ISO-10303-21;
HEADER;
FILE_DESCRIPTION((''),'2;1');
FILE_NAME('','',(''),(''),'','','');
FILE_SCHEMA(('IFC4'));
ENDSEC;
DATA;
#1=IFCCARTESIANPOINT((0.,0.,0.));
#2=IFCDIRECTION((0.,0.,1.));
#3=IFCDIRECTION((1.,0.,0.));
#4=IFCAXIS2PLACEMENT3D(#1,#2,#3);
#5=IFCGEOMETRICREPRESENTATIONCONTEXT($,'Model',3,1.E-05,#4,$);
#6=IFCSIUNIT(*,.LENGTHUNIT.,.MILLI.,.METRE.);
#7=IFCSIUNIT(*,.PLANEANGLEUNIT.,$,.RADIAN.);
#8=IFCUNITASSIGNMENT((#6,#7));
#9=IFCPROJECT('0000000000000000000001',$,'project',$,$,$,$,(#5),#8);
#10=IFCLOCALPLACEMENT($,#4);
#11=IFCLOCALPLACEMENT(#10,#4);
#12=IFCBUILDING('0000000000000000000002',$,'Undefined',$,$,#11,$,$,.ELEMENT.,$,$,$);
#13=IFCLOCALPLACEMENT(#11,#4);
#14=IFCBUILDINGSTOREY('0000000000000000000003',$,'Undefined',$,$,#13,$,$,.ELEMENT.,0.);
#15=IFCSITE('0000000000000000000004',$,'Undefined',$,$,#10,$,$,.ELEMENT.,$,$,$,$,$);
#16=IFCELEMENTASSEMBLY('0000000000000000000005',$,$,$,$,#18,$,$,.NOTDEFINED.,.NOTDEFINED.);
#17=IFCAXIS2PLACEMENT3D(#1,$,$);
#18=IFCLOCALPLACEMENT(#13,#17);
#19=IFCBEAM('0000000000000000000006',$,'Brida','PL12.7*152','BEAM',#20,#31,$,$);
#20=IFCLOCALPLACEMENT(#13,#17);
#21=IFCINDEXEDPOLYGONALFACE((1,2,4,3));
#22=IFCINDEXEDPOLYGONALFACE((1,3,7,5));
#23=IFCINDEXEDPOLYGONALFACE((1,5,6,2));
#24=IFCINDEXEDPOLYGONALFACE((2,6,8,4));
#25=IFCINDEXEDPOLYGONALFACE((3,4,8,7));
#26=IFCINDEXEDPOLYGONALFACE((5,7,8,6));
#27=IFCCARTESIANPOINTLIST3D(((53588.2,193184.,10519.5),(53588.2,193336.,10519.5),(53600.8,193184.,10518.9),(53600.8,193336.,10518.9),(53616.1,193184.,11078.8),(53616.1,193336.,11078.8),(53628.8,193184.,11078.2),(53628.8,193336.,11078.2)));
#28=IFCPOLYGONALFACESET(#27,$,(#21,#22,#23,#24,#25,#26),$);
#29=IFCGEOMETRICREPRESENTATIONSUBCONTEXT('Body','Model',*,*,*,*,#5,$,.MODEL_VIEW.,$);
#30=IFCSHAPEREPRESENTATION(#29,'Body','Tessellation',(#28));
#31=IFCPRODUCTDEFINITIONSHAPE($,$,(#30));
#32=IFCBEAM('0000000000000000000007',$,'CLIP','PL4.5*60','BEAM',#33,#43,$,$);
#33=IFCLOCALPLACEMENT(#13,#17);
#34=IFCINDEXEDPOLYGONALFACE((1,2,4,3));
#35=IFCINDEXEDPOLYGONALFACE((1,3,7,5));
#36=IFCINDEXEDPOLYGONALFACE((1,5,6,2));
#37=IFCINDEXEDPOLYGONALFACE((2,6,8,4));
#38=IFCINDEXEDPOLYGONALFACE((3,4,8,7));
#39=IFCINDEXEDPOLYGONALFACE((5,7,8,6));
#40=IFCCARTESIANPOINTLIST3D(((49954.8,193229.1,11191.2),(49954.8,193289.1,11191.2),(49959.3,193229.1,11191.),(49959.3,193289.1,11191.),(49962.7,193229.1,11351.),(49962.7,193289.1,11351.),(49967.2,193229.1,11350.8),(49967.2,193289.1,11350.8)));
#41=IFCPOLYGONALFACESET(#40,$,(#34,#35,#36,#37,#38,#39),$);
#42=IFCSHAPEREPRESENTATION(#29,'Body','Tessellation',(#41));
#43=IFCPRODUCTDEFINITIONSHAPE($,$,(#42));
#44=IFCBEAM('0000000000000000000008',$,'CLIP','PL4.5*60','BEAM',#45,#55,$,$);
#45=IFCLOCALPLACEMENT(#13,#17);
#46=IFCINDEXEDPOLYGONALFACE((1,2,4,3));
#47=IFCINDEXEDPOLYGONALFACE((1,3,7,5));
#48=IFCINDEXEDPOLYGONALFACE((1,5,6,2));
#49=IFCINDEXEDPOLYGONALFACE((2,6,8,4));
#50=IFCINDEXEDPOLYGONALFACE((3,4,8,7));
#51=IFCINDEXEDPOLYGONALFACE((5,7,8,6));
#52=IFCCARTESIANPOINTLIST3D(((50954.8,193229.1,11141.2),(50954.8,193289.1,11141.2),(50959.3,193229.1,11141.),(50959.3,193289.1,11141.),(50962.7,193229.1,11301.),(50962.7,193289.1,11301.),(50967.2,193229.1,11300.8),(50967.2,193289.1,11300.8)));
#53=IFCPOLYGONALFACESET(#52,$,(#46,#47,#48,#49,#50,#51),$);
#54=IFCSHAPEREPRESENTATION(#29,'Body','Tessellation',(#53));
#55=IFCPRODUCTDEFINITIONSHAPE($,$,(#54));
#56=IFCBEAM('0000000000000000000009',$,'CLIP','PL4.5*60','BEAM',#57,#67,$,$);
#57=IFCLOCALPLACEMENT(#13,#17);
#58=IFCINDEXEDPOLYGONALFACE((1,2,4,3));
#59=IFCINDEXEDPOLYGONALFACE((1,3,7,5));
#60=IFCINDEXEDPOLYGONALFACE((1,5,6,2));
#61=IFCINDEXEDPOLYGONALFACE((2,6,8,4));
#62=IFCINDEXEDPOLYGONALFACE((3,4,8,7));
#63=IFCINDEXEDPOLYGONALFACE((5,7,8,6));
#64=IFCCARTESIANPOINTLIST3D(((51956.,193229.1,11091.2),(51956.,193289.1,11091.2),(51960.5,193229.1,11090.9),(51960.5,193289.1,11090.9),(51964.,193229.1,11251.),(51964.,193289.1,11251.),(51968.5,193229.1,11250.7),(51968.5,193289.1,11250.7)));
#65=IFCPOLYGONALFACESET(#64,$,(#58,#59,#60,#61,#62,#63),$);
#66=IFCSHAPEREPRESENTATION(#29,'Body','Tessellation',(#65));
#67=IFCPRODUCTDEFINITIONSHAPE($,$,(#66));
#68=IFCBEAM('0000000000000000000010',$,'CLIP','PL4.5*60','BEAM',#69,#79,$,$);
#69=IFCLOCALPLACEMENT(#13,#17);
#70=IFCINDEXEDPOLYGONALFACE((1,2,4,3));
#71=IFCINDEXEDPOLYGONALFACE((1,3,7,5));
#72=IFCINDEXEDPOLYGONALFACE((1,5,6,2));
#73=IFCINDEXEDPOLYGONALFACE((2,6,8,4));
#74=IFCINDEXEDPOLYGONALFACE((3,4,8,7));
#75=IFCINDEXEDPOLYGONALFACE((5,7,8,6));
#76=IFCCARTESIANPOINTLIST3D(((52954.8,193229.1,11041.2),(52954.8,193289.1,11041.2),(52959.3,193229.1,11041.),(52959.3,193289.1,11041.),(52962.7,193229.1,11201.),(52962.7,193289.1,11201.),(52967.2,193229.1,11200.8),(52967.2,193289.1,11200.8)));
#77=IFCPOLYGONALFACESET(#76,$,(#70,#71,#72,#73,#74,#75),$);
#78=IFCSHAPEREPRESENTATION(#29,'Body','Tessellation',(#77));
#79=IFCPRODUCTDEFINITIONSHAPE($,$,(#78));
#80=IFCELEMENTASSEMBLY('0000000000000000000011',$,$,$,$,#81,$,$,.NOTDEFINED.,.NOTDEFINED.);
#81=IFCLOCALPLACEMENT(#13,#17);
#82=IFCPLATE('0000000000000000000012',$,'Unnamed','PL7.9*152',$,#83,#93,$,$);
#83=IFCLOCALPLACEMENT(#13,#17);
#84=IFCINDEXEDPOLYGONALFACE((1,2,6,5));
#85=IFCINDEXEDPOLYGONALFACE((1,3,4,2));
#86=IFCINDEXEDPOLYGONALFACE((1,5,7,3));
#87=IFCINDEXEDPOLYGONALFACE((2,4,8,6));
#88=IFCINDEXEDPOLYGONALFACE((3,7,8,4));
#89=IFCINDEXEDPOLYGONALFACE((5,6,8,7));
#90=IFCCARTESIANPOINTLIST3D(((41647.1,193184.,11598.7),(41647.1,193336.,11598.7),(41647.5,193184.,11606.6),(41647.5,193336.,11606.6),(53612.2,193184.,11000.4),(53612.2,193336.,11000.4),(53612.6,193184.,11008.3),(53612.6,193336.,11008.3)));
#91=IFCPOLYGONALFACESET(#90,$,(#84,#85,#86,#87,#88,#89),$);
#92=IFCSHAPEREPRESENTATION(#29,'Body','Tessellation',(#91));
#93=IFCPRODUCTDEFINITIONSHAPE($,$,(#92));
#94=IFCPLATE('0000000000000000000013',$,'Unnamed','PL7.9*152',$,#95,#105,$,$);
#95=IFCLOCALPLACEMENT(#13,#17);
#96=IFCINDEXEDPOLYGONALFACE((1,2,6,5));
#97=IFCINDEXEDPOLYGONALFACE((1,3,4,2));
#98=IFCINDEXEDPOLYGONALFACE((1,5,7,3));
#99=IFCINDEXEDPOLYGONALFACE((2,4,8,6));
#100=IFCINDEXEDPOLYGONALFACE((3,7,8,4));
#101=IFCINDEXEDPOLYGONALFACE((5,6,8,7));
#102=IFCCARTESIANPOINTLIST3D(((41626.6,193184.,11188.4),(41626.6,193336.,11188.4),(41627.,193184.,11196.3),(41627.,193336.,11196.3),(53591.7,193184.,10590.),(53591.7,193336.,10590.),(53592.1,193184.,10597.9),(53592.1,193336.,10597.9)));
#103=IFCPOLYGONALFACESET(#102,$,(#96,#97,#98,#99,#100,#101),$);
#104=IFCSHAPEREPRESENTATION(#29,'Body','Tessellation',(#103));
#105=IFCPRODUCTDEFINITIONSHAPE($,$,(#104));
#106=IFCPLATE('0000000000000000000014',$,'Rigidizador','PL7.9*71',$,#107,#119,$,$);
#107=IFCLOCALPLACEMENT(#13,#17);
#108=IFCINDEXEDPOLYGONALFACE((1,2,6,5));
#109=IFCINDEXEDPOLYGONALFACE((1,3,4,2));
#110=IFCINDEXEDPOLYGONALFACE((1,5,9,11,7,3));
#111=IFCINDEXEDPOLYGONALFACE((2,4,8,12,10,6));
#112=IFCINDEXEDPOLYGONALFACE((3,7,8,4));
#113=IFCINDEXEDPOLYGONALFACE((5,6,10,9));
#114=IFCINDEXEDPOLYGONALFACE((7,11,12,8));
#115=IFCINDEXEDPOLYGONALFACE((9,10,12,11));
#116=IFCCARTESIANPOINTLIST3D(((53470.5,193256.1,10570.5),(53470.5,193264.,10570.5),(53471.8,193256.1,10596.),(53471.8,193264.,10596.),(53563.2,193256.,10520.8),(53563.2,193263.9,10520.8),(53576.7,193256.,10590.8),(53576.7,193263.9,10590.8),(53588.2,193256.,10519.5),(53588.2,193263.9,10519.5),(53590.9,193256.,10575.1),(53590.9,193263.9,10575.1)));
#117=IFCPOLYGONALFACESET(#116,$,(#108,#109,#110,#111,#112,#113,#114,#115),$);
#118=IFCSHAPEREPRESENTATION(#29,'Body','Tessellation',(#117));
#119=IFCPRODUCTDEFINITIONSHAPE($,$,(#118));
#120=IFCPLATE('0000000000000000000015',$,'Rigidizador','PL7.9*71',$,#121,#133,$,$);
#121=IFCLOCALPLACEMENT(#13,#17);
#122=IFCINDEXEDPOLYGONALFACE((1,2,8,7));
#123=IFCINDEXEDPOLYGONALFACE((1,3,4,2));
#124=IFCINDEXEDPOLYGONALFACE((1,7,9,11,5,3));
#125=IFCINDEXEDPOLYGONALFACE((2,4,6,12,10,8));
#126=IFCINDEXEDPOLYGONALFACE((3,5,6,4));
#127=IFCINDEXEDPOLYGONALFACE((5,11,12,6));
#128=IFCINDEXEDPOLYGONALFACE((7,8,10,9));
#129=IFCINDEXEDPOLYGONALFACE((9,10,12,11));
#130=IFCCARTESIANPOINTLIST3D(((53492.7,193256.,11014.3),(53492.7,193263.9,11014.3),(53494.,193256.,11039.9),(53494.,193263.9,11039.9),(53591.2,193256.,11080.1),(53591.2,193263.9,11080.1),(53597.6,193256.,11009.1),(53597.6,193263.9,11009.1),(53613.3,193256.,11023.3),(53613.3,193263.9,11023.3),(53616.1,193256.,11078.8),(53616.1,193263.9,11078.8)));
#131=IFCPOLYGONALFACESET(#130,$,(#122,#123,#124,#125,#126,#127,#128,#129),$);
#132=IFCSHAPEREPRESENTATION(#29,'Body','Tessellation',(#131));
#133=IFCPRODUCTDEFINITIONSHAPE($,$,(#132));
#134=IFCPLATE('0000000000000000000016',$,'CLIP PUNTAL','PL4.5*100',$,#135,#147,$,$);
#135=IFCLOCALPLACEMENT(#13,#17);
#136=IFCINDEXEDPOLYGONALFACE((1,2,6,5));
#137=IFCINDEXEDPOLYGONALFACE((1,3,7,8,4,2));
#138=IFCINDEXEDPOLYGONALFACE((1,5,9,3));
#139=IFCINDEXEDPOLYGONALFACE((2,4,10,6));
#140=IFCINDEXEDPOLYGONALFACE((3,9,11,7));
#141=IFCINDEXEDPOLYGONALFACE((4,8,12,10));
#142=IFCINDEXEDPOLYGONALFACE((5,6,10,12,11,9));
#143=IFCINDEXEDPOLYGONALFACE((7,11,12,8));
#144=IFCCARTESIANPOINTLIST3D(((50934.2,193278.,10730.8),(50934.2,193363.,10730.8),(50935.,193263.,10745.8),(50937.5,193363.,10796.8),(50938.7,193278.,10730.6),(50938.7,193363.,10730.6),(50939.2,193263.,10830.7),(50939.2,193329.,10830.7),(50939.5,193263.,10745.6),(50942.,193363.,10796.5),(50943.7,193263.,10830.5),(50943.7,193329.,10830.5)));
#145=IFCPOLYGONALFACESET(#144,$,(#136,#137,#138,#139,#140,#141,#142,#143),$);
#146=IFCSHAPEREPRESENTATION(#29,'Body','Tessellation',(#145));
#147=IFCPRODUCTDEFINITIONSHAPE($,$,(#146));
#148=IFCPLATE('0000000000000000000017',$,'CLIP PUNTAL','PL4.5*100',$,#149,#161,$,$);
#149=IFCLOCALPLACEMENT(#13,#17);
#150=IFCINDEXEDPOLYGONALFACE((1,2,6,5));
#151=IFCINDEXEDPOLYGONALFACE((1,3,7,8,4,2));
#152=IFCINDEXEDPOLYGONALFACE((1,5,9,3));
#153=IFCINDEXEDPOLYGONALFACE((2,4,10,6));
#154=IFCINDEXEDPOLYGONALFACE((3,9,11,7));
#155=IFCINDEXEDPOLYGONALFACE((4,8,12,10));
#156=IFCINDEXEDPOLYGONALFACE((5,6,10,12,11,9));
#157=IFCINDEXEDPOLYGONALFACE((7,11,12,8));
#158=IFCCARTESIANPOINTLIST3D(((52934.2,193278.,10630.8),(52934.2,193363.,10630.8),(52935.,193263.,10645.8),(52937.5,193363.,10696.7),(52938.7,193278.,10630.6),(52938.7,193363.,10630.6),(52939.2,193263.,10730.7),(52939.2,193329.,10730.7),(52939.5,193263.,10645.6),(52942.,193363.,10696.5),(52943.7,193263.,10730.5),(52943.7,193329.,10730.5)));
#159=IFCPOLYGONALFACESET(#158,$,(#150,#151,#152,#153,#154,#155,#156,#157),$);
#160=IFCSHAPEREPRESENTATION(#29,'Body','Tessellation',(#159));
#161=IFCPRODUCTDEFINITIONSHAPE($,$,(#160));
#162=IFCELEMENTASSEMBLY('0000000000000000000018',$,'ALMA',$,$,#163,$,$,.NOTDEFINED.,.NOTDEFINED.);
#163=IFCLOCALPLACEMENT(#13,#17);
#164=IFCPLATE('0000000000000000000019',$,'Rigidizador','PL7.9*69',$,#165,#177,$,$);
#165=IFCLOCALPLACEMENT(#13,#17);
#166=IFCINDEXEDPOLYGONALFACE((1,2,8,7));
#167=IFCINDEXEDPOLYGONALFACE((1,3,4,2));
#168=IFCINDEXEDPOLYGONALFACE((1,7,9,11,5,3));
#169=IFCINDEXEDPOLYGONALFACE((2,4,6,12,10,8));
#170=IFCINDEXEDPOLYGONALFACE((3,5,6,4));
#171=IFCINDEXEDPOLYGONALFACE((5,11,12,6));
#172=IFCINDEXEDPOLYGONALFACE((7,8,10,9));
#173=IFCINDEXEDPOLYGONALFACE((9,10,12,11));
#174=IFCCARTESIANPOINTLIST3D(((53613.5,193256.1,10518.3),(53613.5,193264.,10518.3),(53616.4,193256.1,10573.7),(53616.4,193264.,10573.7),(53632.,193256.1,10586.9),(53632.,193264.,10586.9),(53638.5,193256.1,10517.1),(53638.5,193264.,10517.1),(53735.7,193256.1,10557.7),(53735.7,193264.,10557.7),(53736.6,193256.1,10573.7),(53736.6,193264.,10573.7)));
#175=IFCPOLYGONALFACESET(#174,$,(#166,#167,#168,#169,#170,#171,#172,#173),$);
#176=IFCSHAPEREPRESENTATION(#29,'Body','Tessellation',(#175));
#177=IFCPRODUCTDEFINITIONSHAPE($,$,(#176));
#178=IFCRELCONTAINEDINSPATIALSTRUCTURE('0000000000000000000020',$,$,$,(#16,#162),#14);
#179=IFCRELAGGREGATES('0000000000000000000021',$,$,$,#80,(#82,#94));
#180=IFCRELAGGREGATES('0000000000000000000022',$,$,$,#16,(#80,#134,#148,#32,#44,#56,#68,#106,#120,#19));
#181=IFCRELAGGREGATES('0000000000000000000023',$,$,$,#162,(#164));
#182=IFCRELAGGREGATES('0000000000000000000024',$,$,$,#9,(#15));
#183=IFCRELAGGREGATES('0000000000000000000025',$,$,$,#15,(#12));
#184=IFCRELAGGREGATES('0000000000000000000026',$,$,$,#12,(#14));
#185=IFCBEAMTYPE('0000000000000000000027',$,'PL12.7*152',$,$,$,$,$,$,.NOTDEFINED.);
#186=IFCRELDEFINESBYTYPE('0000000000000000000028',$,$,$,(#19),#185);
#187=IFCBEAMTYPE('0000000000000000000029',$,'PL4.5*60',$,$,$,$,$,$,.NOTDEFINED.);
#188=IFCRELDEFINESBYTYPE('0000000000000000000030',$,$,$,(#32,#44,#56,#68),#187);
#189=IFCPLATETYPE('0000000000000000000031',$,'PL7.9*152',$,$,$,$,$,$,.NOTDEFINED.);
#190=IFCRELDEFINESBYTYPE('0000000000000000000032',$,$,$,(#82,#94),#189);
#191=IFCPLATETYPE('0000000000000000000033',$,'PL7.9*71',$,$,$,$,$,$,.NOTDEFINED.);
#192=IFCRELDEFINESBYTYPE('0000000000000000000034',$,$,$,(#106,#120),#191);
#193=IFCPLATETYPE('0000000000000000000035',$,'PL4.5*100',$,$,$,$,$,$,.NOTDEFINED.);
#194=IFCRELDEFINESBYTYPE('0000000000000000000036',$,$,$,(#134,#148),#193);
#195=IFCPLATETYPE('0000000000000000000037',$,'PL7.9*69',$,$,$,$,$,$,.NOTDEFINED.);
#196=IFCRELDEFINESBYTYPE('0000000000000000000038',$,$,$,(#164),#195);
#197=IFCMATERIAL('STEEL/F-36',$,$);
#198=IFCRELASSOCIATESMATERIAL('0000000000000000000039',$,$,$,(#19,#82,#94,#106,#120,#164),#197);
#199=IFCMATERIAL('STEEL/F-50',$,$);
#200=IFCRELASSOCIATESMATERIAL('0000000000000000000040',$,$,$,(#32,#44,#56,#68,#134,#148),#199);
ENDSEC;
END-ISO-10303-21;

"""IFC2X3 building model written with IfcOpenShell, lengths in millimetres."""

from ifc_helpers import new_model, si_unit, frame, origin_with_axes, origin_2d_with_axis, place, context, subcontext, project, spatial, polyline, rectangle, outline, extrude, material, type_object, element, aggregate, save


model = new_model("IFC2X3")

# Units and contexts
model_context = context("Model", 3, precision=1e-05, world=origin_with_axes())
body_context = subcontext(model_context, "Body", "Model", "MODEL_VIEW")
ifc_project = project(units=[si_unit("LENGTHUNIT", "METRE", prefix="MILLI"), si_unit("PLANEANGLEUNIT", "RADIAN")], contexts=[model_context])

# Site, building, storey
site_placement = place(None, origin_with_axes())
site = spatial("IfcSite", under=ifc_project, at=site_placement, Name="Undefined", CompositionType="ELEMENT")
building_placement = place(site_placement, origin_with_axes())
building = spatial("IfcBuilding", under=site, at=building_placement, Name="Undefined", CompositionType="ELEMENT")
storey_placement = place(building_placement, origin_with_axes())
storey = spatial("IfcBuildingStorey", under=building, at=storey_placement, Name="Undefined", CompositionType="ELEMENT", Elevation=0.0)

# Element assemblies, beams, plates
assembly_1_placement = place(storey_placement, origin_with_axes())
assembly_1 = element("IfcElementAssembly", 1, at=assembly_1_placement, inside=storey, AssemblyPlace="NOTDEFINED", PredefinedType="NOTDEFINED")
ifc_material_1 = material(Name="STEEL/F-36")
beam_type_1 = type_object("IfcBeamType", Name="PL12.7*152", PredefinedType="NOTDEFINED")
beam_1_placement = place(assembly_1_placement, frame((53622.5, 193260.0, 11078.5), z_axis=(0.0, 1.0, 0.0), x_axis=(-0.049943, 0.0, -0.998752)))
beam_1 = element("IfcBeam", 2, at=beam_1_placement, type_object=beam_type_1, material=ifc_material_1, Name="Brida", Description="PL12.7*152", ObjectType="BEAM", context=body_context, shape_type="SweptSolid", body=[
    extrude(rectangle(XDim=12.7, YDim=152.0, at=origin_2d_with_axis()), frame((560.0, 0.0, 0.0), z_axis=(-1.0, 0.0, 0.0), x_axis=(0.0, -1.0, 0.0)), (0.0, 0.0, 1.0), 560.0),
])
ifc_material_2 = material(Name="STEEL/F-50")
beam_type_2 = type_object("IfcBeamType", Name="PL4.5*60", PredefinedType="NOTDEFINED")
beam_2_placement = place(assembly_1_placement, frame((49965.0, 193259.1, 11350.9), z_axis=(0.0, 1.0, 0.0), x_axis=(-0.049943, 0.0, -0.998752)))
beam_2 = element("IfcBeam", 3, at=beam_2_placement, type_object=beam_type_2, material=ifc_material_2, Name="CLIP", Description="PL4.5*60", ObjectType="BEAM", context=body_context, shape_type="SweptSolid", body=[
    extrude(rectangle(XDim=4.5, YDim=60.0, at=origin_2d_with_axis()), frame((160.0, 0.0, 0.0), z_axis=(-1.0, 0.0, 0.0), x_axis=(0.0, -1.0, 0.0)), (0.0, 0.0, 1.0), 160.0),
])
beam_3_placement = place(assembly_1_placement, frame((50965.0, 193259.1, 11300.9), z_axis=(0.0, 1.0, 0.0), x_axis=(-0.049943, 0.0, -0.998752)))
beam_3 = element("IfcBeam", 4, at=beam_3_placement, type_object=beam_type_2, material=ifc_material_2, Name="CLIP", Description="PL4.5*60", ObjectType="BEAM", context=body_context, shape_type="SweptSolid", body=[
    extrude(rectangle(XDim=4.5, YDim=60.0, at=origin_2d_with_axis()), frame((160.0, 0.0, 0.0), z_axis=(-1.0, 0.0, 0.0), x_axis=(0.0, -1.0, 0.0)), (0.0, 0.0, 1.0), 160.0),
])
beam_4_placement = place(assembly_1_placement, frame((51966.2, 193259.1, 11250.9), z_axis=(0.0, 1.0, 0.0), x_axis=(-0.049943, 0.0, -0.998752)))
beam_4 = element("IfcBeam", 5, at=beam_4_placement, type_object=beam_type_2, material=ifc_material_2, Name="CLIP", Description="PL4.5*60", ObjectType="BEAM", context=body_context, shape_type="SweptSolid", body=[
    extrude(rectangle(XDim=4.5, YDim=60.0, at=origin_2d_with_axis()), frame((160.0, 0.0, 0.0), z_axis=(-1.0, 0.0, 0.0), x_axis=(0.0, -1.0, 0.0)), (0.0, 0.0, 1.0), 160.0),
])
beam_5_placement = place(assembly_1_placement, frame((52965.0, 193259.1, 11200.9), z_axis=(0.0, 1.0, 0.0), x_axis=(-0.049943, 0.0, -0.998752)))
beam_5 = element("IfcBeam", 6, at=beam_5_placement, type_object=beam_type_2, material=ifc_material_2, Name="CLIP", Description="PL4.5*60", ObjectType="BEAM", context=body_context, shape_type="SweptSolid", body=[
    extrude(rectangle(XDim=4.5, YDim=60.0, at=origin_2d_with_axis()), frame((160.0, 0.0, 0.0), z_axis=(-1.0, 0.0, 0.0), x_axis=(0.0, -1.0, 0.0)), (0.0, 0.0, 1.0), 160.0),
])
assembly_2_placement = place(assembly_1_placement, origin_with_axes())
assembly_2 = element("IfcElementAssembly", 7, at=assembly_2_placement, AssemblyPlace="NOTDEFINED", PredefinedType="NOTDEFINED")
plate_type_1 = type_object("IfcPlateType", Name="PL7.9*152", PredefinedType="NOTDEFINED")
plate_1_placement = place(assembly_2_placement, frame((53612.4, 193260.0, 11004.4), z_axis=(-0.049943, 0.0, -0.998752), x_axis=(-0.998752, 0.0, 0.049943)))
plate_1 = element("IfcPlate", 8, at=plate_1_placement, type_object=plate_type_1, material=ifc_material_1, Name="Unnamed", Description="PL7.9*152", context=body_context, shape_type="SweptSolid", body=[
    extrude(outline(polyline([(0.0, -76.0), (0.0, 76.0), (11980.0, 76.0), (11980.0, -76.0), (0.0, -76.0)])), frame((0.0, 0.0, -4.0), z_axis=(0.0, 0.0, 1.0), x_axis=(1.0, 0.0, 0.0)), (0.0, 0.0, 1.0), 7.9),
])
plate_2_placement = place(assembly_2_placement, frame((53591.9, 193260.0, 10594.0), z_axis=(0.049943, 0.0, 0.998752), x_axis=(-0.998752, 0.0, 0.049943)))
plate_2 = element("IfcPlate", 9, at=plate_2_placement, type_object=plate_type_1, material=ifc_material_1, Name="Unnamed", Description="PL7.9*152", context=body_context, shape_type="SweptSolid", body=[
    extrude(outline(polyline([(0.0, -76.0), (0.0, 76.0), (11980.0, 76.0), (11980.0, -76.0), (0.0, -76.0)])), frame((0.0, 0.0, -4.0), z_axis=(0.0, 0.0, 1.0), x_axis=(1.0, 0.0, 0.0)), (0.0, 0.0, 1.0), 7.9),
])
aggregate(assembly_2, [plate_1, plate_2])
plate_type_2 = type_object("IfcPlateType", Name="PL7.9*71", PredefinedType="NOTDEFINED")
plate_3_placement = place(assembly_1_placement, frame((53588.2, 193260.0, 10519.5), z_axis=(0.0, -1.0, 0.0), x_axis=(0.049943, 0.0, 0.998752)))
plate_3 = element("IfcPlate", 10, at=plate_3_placement, type_object=plate_type_2, material=ifc_material_1, Name="Rigidizador", Description="PL7.9*71", context=body_context, shape_type="SweptSolid", body=[
    extrude(outline(polyline([(0.0, 0.0), (55.6, 0.0), (70.6, 15.0), (70.6, 120.0), (45.0, 120.0), (0.0, 25.0), (0.0, 0.0)])), frame((0.0, 0.0, -4.0), z_axis=(0.0, 0.0, 1.0), x_axis=(1.0, 0.0, 0.0)), (0.0, 0.0, 1.0), 7.9),
])
plate_4_placement = place(assembly_1_placement, frame((53616.1, 193260.0, 11078.8), z_axis=(0.0, 1.0, 0.0), x_axis=(-0.049943, 0.0, -0.998752)))
plate_4 = element("IfcPlate", 11, at=plate_4_placement, type_object=plate_type_2, material=ifc_material_1, Name="Rigidizador", Description="PL7.9*71", context=body_context, shape_type="SweptSolid", body=[
    extrude(outline(polyline([(0.0, 0.0), (55.6, 0.0), (70.6, 15.0), (70.6, 120.0), (45.0, 120.0), (0.0, 25.0), (0.0, 0.0)])), frame((0.0, 0.0, -4.0), z_axis=(0.0, 0.0, 1.0), x_axis=(1.0, 0.0, 0.0)), (0.0, 0.0, 1.0), 7.9),
])
plate_type_3 = type_object("IfcPlateType", Name="PL4.5*100", PredefinedType="NOTDEFINED")
plate_5_placement = place(assembly_1_placement, frame((50941.5, 193263.0, 10830.6), z_axis=(-0.998754, 0.0, 0.049896), x_axis=(0.0, 1.0, 0.0)))
plate_5 = element("IfcPlate", 12, at=plate_5_placement, type_object=plate_type_3, material=ifc_material_2, Name="CLIP PUNTAL", Description="PL4.5*100", context=body_context, shape_type="SweptSolid", body=[
    extrude(outline(polyline([(0.0, 0.0), (66.0, 0.0), (100.0, 34.0), (100.0, 100.0), (15.0, 100.0), (0.0, 85.0), (0.0, 0.0)])), frame((0.0, 0.0, -2.2), z_axis=(0.0, 0.0, 1.0), x_axis=(1.0, 0.0, 0.0)), (0.0, 0.0, 1.0), 4.5),
])
plate_6_placement = place(assembly_1_placement, frame((52941.5, 193263.0, 10730.6), z_axis=(-0.998754, 0.0, 0.049896), x_axis=(0.0, 1.0, 0.0)))
plate_6 = element("IfcPlate", 13, at=plate_6_placement, type_object=plate_type_3, material=ifc_material_2, Name="CLIP PUNTAL", Description="PL4.5*100", context=body_context, shape_type="SweptSolid", body=[
    extrude(outline(polyline([(0.0, 0.0), (66.0, 0.0), (100.0, 34.0), (100.0, 100.0), (15.0, 100.0), (0.0, 85.0), (0.0, 0.0)])), frame((0.0, 0.0, -2.2), z_axis=(0.0, 0.0, 1.0), x_axis=(1.0, 0.0, 0.0)), (0.0, 0.0, 1.0), 4.5),
])

# Element assembly, plate
assembly_3_placement = place(storey_placement, origin_with_axes())
assembly_3 = element("IfcElementAssembly", 14, at=assembly_3_placement, inside=storey, Name="ALMA", AssemblyPlace="NOTDEFINED", PredefinedType="NOTDEFINED")
plate_type_4 = type_object("IfcPlateType", Name="PL7.9*69", PredefinedType="NOTDEFINED")
plate_7_placement = place(assembly_3_placement, frame((53613.5, 193260.0, 10518.3), z_axis=(0.0, 1.0, 0.0), x_axis=(0.051067, 0.0, 0.998695)))
plate_7 = element("IfcPlate", 15, at=plate_7_placement, type_object=plate_type_4, material=ifc_material_1, Name="Rigidizador", Description="PL7.9*69", context=body_context, shape_type="SweptSolid", body=[
    extrude(outline(polyline([(0.0, 0.0), (55.6, 0.0), (69.4, 15.0), (61.7, 120.0), (45.6, 120.0), (0.1, 25.0), (0.0, 0.0)])), frame((0.0, 0.0, -4.0), z_axis=(0.0, 0.0, 1.0), x_axis=(1.0, 0.0, 0.0)), (0.0, 0.0, 1.0), 7.9),
])

aggregate(assembly_1, [assembly_2, plate_5, plate_6, beam_2, beam_3, beam_4, beam_5, plate_3, plate_4, beam_1])

aggregate(assembly_3, [plate_7])

save(model, "model.ifc")
